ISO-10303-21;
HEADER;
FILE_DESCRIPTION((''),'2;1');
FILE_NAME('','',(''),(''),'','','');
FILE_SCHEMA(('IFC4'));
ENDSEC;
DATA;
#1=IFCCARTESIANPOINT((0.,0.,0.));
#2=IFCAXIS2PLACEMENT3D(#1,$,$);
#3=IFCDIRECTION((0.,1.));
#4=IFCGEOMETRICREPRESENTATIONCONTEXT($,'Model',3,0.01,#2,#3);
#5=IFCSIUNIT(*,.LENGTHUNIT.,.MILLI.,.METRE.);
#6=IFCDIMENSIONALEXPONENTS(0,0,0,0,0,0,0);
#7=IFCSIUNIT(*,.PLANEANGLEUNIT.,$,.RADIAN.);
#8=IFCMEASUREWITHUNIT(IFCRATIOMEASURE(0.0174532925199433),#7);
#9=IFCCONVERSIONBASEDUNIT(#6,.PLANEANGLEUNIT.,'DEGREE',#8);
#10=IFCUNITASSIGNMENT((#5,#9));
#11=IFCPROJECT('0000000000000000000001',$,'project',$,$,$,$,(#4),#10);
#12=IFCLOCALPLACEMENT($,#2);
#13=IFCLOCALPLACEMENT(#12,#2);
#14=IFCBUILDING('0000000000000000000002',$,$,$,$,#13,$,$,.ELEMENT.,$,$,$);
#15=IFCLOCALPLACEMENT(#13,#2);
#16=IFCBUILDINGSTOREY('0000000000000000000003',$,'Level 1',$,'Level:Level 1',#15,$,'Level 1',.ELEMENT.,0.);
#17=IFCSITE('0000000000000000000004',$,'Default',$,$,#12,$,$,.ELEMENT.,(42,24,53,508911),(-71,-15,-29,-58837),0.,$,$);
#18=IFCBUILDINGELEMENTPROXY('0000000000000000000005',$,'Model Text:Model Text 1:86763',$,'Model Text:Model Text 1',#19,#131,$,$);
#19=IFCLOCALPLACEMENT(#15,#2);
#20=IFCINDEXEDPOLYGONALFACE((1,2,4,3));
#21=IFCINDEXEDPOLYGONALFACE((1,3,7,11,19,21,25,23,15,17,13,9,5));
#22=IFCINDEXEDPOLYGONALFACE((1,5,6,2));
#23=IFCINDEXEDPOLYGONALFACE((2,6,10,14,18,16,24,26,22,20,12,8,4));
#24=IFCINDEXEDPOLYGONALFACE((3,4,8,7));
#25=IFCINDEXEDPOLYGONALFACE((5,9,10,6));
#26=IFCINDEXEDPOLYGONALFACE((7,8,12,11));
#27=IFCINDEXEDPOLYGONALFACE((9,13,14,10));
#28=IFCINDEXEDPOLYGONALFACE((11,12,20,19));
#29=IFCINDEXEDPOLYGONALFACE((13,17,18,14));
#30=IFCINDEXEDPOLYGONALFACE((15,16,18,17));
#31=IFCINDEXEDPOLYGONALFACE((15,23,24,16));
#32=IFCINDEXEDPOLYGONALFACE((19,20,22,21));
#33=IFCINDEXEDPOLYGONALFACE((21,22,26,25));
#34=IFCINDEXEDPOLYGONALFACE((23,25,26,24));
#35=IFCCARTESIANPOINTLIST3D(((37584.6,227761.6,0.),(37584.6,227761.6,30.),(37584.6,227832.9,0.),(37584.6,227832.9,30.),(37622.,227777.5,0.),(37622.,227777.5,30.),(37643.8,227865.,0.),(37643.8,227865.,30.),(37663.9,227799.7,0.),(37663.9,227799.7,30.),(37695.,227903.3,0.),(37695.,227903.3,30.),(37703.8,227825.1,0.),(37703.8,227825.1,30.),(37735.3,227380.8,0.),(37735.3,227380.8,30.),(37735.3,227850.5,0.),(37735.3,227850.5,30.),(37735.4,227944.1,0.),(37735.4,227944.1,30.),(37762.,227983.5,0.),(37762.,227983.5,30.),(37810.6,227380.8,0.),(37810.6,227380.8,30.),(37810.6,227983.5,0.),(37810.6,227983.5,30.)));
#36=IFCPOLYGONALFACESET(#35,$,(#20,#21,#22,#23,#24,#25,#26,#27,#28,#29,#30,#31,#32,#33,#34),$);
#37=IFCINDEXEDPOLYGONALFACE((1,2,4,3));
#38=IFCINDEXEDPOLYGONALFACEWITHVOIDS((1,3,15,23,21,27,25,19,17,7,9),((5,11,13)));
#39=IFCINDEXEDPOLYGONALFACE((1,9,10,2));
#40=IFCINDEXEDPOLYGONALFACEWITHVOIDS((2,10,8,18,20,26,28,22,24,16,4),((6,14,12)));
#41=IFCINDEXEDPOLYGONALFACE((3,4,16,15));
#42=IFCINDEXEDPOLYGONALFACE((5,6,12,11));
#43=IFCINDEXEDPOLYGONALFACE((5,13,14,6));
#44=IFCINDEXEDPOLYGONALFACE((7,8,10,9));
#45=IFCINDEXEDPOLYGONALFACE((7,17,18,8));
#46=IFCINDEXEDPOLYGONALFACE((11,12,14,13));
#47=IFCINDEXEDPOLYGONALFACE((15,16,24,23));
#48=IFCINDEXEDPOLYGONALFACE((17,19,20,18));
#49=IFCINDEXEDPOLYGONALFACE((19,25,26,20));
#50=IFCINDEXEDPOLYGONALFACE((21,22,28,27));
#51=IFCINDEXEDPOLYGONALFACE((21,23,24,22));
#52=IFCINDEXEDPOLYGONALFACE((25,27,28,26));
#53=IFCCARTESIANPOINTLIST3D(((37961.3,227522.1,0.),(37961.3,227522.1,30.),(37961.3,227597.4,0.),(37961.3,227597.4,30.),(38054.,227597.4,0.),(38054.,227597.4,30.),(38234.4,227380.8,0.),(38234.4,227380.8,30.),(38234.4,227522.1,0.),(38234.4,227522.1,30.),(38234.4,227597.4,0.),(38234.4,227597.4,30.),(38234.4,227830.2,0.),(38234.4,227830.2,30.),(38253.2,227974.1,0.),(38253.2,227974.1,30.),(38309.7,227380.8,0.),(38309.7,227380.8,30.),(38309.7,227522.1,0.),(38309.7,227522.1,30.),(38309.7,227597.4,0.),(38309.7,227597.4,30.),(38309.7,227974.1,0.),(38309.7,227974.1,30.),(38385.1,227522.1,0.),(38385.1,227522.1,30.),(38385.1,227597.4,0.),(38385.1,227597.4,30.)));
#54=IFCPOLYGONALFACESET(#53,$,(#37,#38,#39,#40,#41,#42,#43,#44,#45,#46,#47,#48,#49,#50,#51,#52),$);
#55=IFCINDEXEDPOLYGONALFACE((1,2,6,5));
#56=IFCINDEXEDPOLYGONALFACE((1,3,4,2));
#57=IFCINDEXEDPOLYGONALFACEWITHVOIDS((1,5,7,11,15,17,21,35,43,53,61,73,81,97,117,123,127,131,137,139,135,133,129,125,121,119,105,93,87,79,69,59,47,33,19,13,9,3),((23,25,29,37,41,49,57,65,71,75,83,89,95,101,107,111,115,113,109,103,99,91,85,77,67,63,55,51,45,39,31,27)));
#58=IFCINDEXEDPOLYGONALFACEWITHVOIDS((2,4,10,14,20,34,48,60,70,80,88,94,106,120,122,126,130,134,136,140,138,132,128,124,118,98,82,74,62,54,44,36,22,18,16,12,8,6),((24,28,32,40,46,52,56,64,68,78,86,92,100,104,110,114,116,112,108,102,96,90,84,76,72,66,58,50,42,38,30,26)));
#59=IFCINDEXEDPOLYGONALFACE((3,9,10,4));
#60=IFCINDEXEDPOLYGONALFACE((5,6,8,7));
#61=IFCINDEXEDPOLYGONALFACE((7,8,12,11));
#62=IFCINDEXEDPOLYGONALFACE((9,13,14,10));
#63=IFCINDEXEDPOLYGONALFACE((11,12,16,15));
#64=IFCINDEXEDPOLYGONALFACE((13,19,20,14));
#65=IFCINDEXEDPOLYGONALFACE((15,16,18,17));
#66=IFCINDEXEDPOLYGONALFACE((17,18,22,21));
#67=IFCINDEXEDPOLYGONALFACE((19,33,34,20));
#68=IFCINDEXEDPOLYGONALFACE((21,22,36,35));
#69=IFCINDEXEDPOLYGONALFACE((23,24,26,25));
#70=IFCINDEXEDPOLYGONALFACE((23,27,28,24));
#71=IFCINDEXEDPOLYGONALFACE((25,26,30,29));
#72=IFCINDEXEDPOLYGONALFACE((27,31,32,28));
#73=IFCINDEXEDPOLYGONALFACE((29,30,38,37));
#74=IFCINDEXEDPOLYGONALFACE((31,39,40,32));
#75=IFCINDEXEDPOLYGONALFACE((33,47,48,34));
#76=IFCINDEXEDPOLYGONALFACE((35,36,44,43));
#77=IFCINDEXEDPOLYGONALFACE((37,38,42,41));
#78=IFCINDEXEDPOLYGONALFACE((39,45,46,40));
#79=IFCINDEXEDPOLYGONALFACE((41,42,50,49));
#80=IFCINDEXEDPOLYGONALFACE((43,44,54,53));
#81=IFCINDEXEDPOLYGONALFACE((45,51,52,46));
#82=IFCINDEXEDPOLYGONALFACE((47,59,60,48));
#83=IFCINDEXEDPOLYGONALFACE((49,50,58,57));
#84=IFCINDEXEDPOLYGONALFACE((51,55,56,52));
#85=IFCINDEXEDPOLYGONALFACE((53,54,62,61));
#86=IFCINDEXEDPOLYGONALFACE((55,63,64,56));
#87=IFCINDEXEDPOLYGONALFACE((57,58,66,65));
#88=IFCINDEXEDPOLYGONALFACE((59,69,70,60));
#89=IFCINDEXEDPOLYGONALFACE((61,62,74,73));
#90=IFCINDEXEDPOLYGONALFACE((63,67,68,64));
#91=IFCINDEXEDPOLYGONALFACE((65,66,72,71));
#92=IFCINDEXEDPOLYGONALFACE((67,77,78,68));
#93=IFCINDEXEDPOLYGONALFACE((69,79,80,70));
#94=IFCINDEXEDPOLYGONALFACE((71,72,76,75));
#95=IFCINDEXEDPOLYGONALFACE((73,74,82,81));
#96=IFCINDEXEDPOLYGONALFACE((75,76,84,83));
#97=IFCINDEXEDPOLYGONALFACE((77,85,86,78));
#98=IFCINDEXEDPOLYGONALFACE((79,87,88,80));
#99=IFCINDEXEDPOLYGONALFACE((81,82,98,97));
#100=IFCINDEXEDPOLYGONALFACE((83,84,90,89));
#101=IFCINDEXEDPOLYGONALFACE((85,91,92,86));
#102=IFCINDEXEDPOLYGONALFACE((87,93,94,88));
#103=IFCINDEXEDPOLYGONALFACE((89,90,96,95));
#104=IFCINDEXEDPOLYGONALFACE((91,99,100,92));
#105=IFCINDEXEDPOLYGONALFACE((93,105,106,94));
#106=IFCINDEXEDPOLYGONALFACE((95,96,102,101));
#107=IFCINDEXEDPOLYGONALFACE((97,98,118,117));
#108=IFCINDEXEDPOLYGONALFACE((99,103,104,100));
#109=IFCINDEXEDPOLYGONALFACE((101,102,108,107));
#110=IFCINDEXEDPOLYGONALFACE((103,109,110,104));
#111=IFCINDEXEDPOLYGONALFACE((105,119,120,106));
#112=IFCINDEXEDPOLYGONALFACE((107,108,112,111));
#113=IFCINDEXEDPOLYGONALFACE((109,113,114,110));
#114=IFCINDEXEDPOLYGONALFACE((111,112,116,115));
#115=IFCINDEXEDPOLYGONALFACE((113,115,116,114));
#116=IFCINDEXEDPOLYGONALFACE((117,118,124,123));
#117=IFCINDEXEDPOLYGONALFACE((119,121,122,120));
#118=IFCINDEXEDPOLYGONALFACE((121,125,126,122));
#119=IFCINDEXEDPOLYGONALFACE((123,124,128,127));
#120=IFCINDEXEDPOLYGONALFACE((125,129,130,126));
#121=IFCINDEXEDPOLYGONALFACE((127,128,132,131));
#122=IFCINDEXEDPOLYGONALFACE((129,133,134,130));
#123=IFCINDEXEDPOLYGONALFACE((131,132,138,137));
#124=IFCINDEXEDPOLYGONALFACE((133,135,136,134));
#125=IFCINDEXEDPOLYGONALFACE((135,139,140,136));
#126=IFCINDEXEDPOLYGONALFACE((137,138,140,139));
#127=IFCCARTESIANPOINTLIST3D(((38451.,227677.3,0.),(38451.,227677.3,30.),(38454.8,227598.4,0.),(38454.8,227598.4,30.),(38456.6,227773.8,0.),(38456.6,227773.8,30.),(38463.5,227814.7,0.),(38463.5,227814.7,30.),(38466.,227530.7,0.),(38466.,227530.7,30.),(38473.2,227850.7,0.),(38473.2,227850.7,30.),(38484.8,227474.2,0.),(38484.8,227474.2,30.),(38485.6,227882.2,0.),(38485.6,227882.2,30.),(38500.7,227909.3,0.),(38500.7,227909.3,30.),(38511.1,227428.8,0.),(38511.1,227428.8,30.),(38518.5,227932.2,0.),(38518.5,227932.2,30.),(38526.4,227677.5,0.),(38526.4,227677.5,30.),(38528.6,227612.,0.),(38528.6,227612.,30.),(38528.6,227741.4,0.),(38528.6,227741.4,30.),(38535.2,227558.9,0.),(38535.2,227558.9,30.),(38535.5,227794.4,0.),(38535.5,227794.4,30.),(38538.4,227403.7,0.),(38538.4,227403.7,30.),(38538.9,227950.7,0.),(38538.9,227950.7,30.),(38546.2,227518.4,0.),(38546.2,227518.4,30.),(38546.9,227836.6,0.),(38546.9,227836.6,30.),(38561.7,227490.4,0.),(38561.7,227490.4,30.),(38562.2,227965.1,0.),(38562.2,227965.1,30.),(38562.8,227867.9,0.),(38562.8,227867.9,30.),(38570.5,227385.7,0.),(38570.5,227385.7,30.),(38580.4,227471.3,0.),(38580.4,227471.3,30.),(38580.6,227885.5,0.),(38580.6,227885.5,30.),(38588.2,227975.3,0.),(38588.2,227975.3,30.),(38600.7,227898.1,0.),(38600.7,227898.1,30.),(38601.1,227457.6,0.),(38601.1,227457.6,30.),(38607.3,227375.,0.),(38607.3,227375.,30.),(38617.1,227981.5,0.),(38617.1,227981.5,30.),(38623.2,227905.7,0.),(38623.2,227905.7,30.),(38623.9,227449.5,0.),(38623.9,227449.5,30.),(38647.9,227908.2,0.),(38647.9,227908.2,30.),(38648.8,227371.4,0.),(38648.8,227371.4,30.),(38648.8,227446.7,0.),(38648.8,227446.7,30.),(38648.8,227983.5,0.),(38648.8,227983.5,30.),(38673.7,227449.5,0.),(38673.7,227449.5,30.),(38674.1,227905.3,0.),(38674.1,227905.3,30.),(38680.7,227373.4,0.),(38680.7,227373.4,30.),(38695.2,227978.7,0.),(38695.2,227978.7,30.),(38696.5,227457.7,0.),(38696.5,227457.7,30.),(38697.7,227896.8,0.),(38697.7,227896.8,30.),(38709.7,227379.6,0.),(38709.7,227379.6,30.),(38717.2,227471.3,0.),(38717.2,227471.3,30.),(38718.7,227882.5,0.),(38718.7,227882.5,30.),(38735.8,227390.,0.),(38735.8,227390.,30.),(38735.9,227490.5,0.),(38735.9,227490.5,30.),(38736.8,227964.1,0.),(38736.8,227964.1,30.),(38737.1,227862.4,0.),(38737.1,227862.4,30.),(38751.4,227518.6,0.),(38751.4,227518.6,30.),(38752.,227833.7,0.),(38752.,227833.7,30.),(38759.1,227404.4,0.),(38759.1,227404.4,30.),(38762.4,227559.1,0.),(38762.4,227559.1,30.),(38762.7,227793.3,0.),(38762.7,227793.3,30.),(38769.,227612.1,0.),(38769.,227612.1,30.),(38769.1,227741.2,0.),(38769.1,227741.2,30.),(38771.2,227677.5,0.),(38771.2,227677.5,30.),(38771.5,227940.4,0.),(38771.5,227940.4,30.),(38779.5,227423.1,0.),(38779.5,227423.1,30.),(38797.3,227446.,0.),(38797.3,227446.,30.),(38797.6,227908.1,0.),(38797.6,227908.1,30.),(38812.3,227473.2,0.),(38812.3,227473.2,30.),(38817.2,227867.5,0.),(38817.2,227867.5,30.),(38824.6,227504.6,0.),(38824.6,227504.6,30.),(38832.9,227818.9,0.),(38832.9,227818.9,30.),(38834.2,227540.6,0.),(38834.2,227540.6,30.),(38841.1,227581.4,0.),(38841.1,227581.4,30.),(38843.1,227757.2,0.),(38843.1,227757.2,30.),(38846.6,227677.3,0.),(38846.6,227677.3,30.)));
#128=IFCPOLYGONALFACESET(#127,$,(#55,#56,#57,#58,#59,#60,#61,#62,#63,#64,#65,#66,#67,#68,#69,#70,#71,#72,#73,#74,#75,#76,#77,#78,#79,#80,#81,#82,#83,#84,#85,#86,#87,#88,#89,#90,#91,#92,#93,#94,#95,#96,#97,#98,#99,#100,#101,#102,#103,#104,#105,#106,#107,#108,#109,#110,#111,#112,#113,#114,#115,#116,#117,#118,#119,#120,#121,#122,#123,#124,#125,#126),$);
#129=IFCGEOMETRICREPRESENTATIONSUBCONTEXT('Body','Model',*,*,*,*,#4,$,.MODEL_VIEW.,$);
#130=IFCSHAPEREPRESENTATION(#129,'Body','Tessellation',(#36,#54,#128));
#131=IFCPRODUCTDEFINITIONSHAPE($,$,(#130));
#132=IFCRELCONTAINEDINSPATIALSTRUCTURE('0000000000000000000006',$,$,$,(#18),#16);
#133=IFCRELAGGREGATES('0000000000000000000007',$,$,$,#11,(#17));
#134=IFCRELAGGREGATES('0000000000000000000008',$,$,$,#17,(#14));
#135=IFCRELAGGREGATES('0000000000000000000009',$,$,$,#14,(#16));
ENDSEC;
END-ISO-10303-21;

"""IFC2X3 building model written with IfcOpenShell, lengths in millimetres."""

from ifc_helpers import new_model, entity, si_unit, converted_unit, direction, frame, origin, place, context, subcontext, project, spatial, polyline, outline, extrude, element, save


model = new_model("IFC2X3")

# Units and contexts
model_context = context("Model", 3, precision=0.01, world=origin(), true_north=direction((0.0, 1.0)))
body_context = subcontext(model_context, "Body", "Model", "MODEL_VIEW")
ifc_project = project(units=[si_unit("LENGTHUNIT", "METRE", prefix="MILLI"), converted_unit("PLANEANGLEUNIT", "DEGREE", entity("IfcRatioMeasure", 0.0174532925199433), si_unit("PLANEANGLEUNIT", "RADIAN"), dimensions=[0, 0, 0, 0, 0, 0, 0])], contexts=[model_context])

# Site, building, storey
site_placement = place(None, origin())
site = spatial("IfcSite", under=ifc_project, at=site_placement, Name="Default", CompositionType="ELEMENT", RefLatitude=(42, 24, 53, 508911), RefLongitude=(-71, -15, -29, -58837), RefElevation=0.0)
building_placement = place(site_placement, origin())
building = spatial("IfcBuilding", under=site, at=building_placement, CompositionType="ELEMENT")
storey_placement = place(building_placement, origin())
storey = spatial("IfcBuildingStorey", under=building, at=storey_placement, Name="Level 1", ObjectType="Level:Level 1", LongName="Level 1", CompositionType="ELEMENT", Elevation=0.0)

# Building element proxy
proxy_1_placement = place(storey_placement, origin())
element("IfcBuildingElementProxy", 1, at=proxy_1_placement, inside=storey, Name="Model Text:Model Text 1:86763", ObjectType="Model Text:Model Text 1", context=body_context, shape_type="SweptSolid", body=[
    extrude(outline(polyline([(-410.6, -111.6), (192.1, -111.6), (192.1, -63.1), (152.7, -36.4), (111.9, 4.0), (73.6, 55.2), (41.4, 114.4), (-29.8, 114.4), (-13.9, 77.0), (8.3, 35.1), (33.7, -4.8), (59.1, -36.3), (-410.6, -36.3), (-410.6, -111.6)])), frame((37699.0, 227791.4, 0.0), z_axis=(0.0, 0.0, 1.0), x_axis=(0.0, 1.0, 0.0)), (0.0, 0.0, 1.0), 30.0),
    extrude(outline(polyline([(-6.8, -218.3), (68.5, -218.3), (68.5, -77.1), (143.8, -77.1), (143.8, -1.7), (68.5, -1.7), (68.5, 375.0), (12.0, 375.0), (-280.0, -1.7), (-280.0, -77.1), (-6.8, -77.1), (-6.8, -218.3)]), holes=[polyline([(-6.8, -1.7), (-187.3, -1.7), (-6.8, 231.1), (-6.8, -1.7)])]), frame((38241.3, 227599.1, 0.0)), (0.0, 0.0, 1.0), 30.0),
    extrude(outline(polyline([(-10.6, -198.7), (68.3, -198.7), (136.5, -190.7), (193.9, -174.7), (240.5, -150.6), (266.9, -124.4), (286.3, -93.2), (298.8, -57.0), (304.3, -15.7), (303.8, 16.2), (299.0, 45.5), (289.9, 72.1), (276.6, 96.0), (258.9, 117.3), (236.9, 136.2), (210.4, 152.5), (179.6, 166.3), (144.1, 177.6), (103.7, 186.3), (8.2, 196.4), (-71.8, 196.7), (-134.0, 189.4), (-183.3, 176.1), (-224.7, 158.4), (-258.2, 133.9), (-283.5, 100.3), (-300.1, 59.5), (-307.1, 13.4), (-306.6, -18.4), (-301.8, -47.5), (-292.8, -74.0), (-279.6, -97.9), (-262.0, -119.2), (-240.0, -138.1), (-213.6, -154.5), (-182.8, -168.4), (-147.3, -179.8), (-106.7, -188.6), (-10.6, -198.7)]), holes=[polyline([(-7.2, -123.5), (-71.0, -118.2), (-123.6, -108.8), (-165.2, -95.4), (-195.7, -78.0), (-212.4, -59.4), (-224.1, -38.7), (-230.6, -15.9), (-231.9, 8.9), (-227.8, 35.0), (-218.1, 58.1), (-202.8, 78.4), (-182.0, 95.8), (-152.6, 109.4), (-111.7, 118.1), (-59.4, 122.0), (4.4, 121.1), (69.6, 115.8), (122.2, 106.7), (162.2, 93.7), (189.5, 77.0), (207.7, 57.4), (220.4, 36.0), (227.5, 12.8), (229.1, -12.1), (225.2, -36.8), (215.9, -59.2), (201.3, -79.3), (181.4, -97.1), (152.6, -111.2), (111.6, -120.3), (58.3, -124.4), (-7.2, -123.5)])]), frame((38650.0, 227676.1, 0.0), z_axis=(0.0, 0.0, 1.0), x_axis=(0.047515, -0.998871, 0.0)), (0.0, 0.0, 1.0), 30.0),
])

save(model, "model.ifc")
